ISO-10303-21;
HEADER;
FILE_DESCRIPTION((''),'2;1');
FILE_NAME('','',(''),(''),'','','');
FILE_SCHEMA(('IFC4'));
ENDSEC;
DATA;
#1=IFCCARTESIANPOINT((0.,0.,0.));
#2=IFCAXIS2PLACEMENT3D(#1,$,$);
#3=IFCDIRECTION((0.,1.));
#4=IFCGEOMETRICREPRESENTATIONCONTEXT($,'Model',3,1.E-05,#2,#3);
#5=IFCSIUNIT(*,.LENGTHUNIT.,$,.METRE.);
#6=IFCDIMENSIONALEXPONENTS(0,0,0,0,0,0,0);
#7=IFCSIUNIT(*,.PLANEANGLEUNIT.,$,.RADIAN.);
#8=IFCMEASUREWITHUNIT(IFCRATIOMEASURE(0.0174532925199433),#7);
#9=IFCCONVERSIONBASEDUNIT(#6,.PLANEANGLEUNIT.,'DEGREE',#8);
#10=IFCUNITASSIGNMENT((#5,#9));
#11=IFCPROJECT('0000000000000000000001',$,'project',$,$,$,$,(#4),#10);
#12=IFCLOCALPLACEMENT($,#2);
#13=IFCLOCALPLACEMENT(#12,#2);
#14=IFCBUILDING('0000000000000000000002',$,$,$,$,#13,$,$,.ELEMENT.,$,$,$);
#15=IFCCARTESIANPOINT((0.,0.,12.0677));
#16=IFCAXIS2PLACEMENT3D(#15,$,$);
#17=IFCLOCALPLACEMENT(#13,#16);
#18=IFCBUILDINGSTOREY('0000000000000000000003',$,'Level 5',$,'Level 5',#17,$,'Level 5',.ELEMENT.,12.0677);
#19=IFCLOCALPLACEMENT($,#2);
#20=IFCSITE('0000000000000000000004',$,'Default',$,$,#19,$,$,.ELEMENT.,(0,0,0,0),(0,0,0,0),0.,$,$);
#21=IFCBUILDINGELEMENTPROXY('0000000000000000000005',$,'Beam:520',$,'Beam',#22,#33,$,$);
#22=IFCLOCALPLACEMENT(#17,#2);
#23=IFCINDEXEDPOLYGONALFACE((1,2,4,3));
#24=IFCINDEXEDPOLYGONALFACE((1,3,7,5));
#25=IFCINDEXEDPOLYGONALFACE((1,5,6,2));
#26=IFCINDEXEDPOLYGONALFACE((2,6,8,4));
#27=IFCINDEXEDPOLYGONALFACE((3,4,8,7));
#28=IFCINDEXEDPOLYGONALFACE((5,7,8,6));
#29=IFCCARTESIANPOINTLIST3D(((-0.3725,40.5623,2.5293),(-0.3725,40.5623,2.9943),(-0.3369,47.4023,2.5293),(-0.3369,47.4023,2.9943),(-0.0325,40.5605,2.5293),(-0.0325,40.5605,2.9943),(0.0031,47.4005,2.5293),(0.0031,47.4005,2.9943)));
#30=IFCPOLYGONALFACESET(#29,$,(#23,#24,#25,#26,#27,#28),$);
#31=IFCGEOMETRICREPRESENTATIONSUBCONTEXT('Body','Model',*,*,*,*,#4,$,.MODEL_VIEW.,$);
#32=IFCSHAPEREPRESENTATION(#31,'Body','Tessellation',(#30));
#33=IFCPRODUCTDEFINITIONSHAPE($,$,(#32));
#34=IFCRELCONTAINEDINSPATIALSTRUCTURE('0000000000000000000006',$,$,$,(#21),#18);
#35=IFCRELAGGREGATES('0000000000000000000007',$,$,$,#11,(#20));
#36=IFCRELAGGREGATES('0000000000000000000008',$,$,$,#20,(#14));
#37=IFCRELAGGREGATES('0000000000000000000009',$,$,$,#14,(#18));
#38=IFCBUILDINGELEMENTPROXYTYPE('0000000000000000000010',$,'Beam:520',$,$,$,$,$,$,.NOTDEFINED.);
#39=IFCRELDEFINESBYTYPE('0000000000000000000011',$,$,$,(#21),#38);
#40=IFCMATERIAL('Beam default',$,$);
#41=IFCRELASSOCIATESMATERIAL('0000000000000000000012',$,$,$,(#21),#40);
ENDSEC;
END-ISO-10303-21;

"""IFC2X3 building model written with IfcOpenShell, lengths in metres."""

from ifc_helpers import new_model, entity, si_unit, converted_unit, direction, frame, origin, place, context, subcontext, project, spatial, polyline, outline, extrude, source, transform, mapped, material, type_object, type_shapes, element, save


model = new_model("IFC2X3")

# Units and contexts
model_context = context("Model", 3, precision=1e-05, world=origin(), true_north=direction((0.0, 1.0)))
body_context = subcontext(model_context, "Body", "Model", "MODEL_VIEW")
ifc_project = project(units=[si_unit("LENGTHUNIT", "METRE"), converted_unit("PLANEANGLEUNIT", "DEGREE", entity("IfcRatioMeasure", 0.0174532925199433), si_unit("PLANEANGLEUNIT", "RADIAN"), dimensions=[0, 0, 0, 0, 0, 0, 0])], contexts=[model_context])

# Site, building, storey
site_placement = place(None, origin())
site = spatial("IfcSite", under=ifc_project, at=site_placement, Name="Default", CompositionType="ELEMENT", RefLatitude=(0, 0, 0, 0), RefLongitude=(0, 0, 0, 0), RefElevation=0.0)
placement_1 = place(None, origin())
building_placement = place(placement_1, origin())
building = spatial("IfcBuilding", under=site, at=building_placement, CompositionType="ELEMENT")
storey_placement = place(building_placement, frame((0.0, 0.0, 12.0677)))
storey = spatial("IfcBuildingStorey", under=building, at=storey_placement, Name="Level 5", ObjectType="Level 5", LongName="Level 5", CompositionType="ELEMENT", Elevation=12.0677)

# Building element proxy
ifc_material_1 = material(Name="Beam default")
building_element_proxy_type_1 = type_object("IfcBuildingElementProxyType", Name="Beam:520", PredefinedType="NOTDEFINED")
shared_shape_1 = source(origin(), body_context, "Body", "SweptSolid", [
    extrude(outline(polyline([(6.8401, -0.17), (6.8401, 0.17), (0.0, 0.17), (0.0, -0.17), (6.8401, -0.17)])), origin(), (0.0, 0.0, 1.0), 0.465),
])
type_shapes(building_element_proxy_type_1, [shared_shape_1])
placement_2 = place(building_placement, frame((0.0, 0.0, 14.597)))
proxy_1_placement = place(placement_2, frame((-0.1669, 47.4014, 0.0), z_axis=(0.0, 0.0, 1.0), x_axis=(-0.005207, -0.999986, 0.0)))
element("IfcBuildingElementProxy", 1, at=proxy_1_placement, inside=storey, type_object=building_element_proxy_type_1, material=ifc_material_1, Name="Beam:520", ObjectType="Beam", context=body_context, shape_type="MappedRepresentation", body=[
    mapped(shared_shape_1, transform((0.0, 0.0, 0.0), scale=1.0)),
])

save(model, "model.ifc")
